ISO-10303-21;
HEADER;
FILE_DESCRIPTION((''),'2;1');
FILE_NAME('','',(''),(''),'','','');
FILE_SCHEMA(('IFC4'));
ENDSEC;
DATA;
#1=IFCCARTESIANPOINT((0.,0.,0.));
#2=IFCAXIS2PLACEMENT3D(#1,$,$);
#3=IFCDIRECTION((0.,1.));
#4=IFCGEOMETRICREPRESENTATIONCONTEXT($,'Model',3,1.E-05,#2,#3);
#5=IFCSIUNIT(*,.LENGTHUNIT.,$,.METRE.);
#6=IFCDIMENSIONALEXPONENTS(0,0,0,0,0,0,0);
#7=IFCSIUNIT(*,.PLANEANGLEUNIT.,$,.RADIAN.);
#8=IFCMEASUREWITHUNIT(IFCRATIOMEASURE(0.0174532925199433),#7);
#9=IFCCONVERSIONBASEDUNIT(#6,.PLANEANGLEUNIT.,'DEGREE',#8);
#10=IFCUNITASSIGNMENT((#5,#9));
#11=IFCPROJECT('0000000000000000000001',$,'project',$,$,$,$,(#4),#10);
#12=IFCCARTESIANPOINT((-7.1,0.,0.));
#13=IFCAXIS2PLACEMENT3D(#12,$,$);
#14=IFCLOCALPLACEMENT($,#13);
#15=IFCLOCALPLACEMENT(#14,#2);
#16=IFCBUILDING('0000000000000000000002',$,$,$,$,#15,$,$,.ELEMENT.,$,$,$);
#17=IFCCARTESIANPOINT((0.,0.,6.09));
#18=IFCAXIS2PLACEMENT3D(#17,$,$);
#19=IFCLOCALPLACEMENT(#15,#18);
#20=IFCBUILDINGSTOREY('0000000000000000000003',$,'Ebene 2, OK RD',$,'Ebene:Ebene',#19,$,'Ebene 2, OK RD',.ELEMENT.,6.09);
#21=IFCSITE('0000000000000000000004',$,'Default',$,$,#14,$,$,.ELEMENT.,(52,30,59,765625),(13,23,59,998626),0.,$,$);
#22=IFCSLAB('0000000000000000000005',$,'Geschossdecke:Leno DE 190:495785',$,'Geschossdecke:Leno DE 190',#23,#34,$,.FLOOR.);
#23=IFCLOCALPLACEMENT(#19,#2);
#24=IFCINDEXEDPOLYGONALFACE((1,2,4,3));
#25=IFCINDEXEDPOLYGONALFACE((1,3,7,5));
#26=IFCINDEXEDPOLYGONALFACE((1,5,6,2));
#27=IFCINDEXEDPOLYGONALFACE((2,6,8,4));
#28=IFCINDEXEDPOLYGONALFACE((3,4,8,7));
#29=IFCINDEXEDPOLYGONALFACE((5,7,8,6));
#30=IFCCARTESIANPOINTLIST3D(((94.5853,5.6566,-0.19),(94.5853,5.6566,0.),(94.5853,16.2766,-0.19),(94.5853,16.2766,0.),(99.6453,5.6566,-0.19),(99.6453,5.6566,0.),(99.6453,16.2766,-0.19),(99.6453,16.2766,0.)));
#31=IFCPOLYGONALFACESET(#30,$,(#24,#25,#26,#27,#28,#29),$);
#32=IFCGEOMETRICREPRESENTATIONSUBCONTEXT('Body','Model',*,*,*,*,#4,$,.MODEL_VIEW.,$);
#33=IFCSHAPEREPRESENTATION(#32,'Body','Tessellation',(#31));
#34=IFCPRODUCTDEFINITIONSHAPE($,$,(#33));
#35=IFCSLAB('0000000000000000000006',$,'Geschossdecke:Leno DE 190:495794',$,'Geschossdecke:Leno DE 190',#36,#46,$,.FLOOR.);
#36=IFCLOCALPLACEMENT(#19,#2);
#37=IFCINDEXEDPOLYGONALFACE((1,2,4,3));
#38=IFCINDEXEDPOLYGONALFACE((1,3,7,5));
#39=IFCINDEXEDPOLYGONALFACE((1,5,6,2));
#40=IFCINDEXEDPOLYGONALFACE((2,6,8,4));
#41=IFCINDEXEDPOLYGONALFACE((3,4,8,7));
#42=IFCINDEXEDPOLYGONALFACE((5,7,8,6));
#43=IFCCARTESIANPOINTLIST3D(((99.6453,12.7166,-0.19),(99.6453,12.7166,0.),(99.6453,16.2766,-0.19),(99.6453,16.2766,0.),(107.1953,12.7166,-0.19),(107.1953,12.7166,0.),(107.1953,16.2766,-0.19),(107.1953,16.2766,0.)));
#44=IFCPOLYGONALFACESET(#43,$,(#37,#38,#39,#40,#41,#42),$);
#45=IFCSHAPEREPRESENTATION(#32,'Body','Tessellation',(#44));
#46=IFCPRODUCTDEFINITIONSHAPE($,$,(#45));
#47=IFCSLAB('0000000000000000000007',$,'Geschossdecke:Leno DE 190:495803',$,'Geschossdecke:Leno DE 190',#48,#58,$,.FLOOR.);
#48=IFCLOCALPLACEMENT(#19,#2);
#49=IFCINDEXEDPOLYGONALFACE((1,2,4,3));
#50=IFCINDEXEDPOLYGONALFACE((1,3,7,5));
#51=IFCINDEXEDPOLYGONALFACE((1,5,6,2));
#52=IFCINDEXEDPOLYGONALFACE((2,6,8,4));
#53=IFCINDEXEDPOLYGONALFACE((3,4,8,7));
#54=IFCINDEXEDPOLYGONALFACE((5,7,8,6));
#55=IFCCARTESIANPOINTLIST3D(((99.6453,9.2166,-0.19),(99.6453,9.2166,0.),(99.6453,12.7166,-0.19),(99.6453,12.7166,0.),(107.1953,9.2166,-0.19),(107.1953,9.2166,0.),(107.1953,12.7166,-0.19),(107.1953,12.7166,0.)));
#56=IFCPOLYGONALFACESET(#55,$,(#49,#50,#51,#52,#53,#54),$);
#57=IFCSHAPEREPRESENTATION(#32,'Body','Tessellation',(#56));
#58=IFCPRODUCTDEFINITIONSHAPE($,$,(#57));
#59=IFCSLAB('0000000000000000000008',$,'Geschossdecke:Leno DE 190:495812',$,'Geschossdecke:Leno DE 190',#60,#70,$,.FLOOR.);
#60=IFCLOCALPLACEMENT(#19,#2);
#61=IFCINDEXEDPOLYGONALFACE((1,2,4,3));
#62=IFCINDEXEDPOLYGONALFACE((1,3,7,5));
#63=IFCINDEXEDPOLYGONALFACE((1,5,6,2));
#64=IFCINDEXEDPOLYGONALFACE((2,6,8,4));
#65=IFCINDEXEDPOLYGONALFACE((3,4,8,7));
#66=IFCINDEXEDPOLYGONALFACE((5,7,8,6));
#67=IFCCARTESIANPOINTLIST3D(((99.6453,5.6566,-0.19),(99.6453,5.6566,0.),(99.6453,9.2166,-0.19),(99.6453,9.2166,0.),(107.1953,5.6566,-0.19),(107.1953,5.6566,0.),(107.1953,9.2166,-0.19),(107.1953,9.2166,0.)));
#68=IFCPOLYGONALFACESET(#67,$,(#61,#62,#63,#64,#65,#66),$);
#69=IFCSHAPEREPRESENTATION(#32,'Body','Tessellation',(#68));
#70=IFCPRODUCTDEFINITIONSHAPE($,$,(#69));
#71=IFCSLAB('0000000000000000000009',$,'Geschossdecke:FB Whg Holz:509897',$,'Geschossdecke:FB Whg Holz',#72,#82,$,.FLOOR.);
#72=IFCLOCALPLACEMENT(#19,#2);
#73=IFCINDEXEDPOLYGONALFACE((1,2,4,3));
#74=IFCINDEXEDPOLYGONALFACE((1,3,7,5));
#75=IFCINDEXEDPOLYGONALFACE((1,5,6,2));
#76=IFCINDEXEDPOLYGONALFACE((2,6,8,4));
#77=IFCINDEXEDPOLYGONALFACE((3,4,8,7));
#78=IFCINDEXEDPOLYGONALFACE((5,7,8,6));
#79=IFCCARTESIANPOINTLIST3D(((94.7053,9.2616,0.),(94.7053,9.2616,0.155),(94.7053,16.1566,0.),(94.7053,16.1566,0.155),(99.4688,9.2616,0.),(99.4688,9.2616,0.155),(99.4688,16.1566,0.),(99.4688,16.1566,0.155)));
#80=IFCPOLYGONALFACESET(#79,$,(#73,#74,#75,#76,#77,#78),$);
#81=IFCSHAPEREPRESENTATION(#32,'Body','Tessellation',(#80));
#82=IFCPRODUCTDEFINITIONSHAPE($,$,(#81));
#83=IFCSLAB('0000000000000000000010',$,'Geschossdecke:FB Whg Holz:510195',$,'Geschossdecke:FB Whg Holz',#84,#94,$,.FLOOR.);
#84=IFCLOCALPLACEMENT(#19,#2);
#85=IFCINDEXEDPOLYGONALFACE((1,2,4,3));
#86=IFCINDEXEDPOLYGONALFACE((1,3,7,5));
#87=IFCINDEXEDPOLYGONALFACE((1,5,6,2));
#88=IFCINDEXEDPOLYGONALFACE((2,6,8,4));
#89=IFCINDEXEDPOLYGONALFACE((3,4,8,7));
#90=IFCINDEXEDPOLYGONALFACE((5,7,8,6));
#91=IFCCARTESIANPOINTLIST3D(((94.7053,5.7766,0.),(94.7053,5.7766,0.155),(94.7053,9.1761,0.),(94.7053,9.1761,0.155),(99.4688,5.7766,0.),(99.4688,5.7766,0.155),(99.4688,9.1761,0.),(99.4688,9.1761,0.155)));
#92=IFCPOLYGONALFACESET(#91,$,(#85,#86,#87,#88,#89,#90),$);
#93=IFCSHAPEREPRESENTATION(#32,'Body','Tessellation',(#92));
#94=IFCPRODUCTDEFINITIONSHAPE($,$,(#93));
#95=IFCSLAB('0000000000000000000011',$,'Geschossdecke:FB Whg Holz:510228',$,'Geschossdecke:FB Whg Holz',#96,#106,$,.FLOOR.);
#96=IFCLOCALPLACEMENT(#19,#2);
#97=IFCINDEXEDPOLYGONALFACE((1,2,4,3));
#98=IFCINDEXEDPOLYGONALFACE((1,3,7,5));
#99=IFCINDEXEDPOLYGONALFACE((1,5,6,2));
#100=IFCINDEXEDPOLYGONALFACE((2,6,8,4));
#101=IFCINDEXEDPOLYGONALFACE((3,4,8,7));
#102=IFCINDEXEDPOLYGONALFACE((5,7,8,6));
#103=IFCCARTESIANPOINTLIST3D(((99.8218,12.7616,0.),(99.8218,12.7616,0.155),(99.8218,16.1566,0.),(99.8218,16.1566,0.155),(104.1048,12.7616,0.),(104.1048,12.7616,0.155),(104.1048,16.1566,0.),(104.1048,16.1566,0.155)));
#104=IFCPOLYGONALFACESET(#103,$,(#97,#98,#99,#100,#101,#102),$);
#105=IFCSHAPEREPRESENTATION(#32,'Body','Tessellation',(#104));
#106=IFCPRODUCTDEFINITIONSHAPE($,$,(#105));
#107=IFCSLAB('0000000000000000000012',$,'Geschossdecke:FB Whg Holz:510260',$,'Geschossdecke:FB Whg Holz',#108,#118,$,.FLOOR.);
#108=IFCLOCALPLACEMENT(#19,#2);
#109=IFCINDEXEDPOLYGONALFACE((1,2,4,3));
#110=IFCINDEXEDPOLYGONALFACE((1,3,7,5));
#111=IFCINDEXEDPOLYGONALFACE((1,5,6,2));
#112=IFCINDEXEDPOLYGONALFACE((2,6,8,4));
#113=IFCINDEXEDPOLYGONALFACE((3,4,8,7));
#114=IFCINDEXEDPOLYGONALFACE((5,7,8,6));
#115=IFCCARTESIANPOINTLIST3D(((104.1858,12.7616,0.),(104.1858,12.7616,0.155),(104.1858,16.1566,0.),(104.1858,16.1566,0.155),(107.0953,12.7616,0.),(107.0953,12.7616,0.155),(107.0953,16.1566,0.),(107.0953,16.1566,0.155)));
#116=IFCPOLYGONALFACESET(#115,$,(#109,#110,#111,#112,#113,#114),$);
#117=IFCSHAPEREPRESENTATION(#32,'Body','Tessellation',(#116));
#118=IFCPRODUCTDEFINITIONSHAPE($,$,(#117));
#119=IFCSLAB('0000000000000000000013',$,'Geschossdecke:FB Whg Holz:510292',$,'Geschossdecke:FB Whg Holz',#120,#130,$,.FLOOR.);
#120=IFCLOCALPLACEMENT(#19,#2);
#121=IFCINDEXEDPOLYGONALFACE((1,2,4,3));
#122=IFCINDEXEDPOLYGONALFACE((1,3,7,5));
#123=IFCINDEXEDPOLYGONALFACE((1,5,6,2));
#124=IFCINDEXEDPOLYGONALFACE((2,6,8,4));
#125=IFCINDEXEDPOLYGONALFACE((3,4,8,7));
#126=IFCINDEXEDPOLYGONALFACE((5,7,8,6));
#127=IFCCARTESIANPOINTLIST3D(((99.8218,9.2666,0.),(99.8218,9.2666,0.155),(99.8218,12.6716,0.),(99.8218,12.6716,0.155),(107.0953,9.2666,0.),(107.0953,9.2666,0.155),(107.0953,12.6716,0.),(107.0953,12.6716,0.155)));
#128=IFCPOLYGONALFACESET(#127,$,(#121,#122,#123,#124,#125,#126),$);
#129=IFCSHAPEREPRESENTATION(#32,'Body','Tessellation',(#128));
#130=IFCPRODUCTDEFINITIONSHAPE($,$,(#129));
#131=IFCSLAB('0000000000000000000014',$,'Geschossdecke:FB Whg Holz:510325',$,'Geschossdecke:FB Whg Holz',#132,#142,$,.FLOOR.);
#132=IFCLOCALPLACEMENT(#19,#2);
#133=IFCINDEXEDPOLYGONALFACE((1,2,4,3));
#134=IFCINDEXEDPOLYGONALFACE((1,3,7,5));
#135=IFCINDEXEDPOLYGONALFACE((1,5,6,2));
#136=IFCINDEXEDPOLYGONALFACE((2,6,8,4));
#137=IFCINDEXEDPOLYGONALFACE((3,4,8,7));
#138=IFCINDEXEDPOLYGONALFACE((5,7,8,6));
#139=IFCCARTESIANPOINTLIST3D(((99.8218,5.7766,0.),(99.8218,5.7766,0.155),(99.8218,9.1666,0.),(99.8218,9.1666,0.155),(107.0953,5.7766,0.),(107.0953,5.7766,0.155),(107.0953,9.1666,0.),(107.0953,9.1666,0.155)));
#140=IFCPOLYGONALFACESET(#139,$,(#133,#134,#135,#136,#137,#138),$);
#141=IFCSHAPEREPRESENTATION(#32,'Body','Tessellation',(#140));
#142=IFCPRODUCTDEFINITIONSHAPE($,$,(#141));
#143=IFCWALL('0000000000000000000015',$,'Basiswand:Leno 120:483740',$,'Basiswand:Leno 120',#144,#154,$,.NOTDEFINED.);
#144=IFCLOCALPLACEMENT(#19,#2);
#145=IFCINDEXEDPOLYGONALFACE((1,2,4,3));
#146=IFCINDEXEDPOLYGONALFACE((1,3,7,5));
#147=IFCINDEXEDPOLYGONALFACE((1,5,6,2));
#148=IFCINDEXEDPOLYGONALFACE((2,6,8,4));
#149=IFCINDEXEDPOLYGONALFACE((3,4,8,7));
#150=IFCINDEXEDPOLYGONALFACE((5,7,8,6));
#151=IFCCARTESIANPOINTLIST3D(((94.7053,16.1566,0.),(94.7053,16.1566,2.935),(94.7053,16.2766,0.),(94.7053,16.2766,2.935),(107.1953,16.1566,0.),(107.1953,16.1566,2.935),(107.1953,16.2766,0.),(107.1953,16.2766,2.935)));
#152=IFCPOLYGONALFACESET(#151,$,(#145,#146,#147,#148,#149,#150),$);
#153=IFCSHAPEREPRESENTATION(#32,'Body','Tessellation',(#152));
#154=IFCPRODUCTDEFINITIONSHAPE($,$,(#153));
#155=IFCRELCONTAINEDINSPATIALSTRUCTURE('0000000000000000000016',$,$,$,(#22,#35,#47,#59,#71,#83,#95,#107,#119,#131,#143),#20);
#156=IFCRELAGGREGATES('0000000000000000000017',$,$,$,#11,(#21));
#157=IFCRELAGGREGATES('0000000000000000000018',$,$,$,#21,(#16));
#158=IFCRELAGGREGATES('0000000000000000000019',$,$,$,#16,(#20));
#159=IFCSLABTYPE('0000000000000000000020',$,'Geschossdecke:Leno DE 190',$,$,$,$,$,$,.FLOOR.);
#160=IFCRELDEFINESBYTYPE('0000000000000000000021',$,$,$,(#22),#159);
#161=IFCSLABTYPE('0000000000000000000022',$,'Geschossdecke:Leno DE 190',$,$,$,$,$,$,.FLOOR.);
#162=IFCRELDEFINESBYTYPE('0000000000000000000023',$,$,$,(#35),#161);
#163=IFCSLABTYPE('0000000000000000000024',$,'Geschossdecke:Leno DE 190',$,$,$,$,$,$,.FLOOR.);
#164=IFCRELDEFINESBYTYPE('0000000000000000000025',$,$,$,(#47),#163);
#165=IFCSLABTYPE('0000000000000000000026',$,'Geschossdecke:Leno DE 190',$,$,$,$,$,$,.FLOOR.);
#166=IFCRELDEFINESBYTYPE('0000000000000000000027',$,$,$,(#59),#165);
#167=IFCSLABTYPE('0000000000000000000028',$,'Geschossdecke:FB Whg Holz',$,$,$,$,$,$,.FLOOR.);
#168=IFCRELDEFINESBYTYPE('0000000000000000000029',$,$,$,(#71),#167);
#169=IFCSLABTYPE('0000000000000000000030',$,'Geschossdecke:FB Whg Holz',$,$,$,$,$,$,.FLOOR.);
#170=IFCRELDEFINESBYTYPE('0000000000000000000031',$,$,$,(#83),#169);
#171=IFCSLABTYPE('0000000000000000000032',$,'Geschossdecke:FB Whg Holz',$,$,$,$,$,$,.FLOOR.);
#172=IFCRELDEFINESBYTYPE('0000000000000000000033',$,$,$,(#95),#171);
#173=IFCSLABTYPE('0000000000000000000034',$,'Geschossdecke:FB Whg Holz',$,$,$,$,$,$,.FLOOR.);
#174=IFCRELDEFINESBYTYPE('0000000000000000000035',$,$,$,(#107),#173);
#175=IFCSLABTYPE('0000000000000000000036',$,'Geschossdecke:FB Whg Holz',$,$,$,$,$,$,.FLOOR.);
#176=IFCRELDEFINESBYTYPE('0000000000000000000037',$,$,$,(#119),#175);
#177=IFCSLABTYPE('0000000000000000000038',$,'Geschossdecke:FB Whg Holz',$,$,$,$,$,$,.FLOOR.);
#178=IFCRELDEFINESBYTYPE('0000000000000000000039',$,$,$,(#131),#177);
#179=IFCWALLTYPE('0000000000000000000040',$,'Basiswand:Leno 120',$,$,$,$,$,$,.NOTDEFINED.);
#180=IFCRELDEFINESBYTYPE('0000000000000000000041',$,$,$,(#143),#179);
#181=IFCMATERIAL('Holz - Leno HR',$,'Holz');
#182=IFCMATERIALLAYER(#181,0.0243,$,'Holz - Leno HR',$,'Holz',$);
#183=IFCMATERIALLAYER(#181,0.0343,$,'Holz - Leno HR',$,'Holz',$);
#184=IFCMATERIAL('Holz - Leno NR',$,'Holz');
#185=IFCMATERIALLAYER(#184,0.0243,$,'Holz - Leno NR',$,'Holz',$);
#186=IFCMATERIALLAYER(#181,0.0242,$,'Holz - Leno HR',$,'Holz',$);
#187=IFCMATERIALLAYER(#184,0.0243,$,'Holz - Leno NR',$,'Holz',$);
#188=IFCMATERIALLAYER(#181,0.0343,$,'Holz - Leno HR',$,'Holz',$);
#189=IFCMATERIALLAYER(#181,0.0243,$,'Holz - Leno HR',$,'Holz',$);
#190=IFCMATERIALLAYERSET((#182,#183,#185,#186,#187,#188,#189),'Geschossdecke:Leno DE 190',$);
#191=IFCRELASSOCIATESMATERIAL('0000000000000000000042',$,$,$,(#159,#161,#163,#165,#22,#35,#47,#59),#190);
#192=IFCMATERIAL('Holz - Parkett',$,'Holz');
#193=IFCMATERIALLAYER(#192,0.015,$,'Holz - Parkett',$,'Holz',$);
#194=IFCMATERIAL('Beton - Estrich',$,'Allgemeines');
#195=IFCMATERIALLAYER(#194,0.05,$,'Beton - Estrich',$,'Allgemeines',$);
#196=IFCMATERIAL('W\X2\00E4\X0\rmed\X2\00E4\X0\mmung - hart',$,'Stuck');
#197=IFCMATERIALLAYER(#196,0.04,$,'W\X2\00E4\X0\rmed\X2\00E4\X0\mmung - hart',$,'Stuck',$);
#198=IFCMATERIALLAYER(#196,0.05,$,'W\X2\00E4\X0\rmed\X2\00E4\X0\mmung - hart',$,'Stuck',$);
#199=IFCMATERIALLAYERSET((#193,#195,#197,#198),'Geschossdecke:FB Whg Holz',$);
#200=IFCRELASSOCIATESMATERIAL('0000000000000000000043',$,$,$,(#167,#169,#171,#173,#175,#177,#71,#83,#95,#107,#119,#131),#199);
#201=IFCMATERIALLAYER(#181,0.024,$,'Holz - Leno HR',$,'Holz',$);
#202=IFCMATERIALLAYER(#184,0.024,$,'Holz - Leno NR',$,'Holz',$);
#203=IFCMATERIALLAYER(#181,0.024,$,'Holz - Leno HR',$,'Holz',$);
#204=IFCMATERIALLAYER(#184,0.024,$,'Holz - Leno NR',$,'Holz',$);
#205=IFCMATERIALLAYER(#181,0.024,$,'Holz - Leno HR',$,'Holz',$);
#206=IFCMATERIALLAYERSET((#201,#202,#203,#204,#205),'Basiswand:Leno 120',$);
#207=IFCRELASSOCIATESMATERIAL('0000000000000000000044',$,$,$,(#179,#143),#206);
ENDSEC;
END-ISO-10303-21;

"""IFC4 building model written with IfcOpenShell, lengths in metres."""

from ifc_helpers import new_model, entity, si_unit, converted_unit, direction, frame, frame_2d, origin, origin_2d_with_axis, place, context, subcontext, project, spatial, rectangle, extrude, material, layer, layer_set, layer_usage, type_object, element, save


model = new_model("IFC4")

# Units and contexts
model_context = context("Model", 3, precision=1e-05, world=origin(), true_north=direction((0.0, 1.0)))
body_context = subcontext(model_context, "Body", "Model", "MODEL_VIEW")
ifc_project = project(units=[si_unit("LENGTHUNIT", "METRE"), converted_unit("PLANEANGLEUNIT", "DEGREE", entity("IfcRatioMeasure", 0.0174532925199433), si_unit("PLANEANGLEUNIT", "RADIAN"), dimensions=[0, 0, 0, 0, 0, 0, 0])], contexts=[model_context])

# Site, building, storey
site_placement = place(None, frame((-7.1, 0.0, 0.0)))
site = spatial("IfcSite", under=ifc_project, at=site_placement, Name="Default", CompositionType="ELEMENT", RefLatitude=(52, 30, 59, 765625), RefLongitude=(13, 23, 59, 998626), RefElevation=0.0)
building_placement = place(site_placement, origin())
building = spatial("IfcBuilding", under=site, at=building_placement, CompositionType="ELEMENT")
storey_placement = place(building_placement, frame((0.0, 0.0, 6.09)))
storey = spatial("IfcBuildingStorey", under=building, at=storey_placement, Name="Ebene 2, OK RD", ObjectType="Ebene:Ebene", LongName="Ebene 2, OK RD", CompositionType="ELEMENT", Elevation=6.09)

# Slabs
ifc_material_1 = material(Name="Holz - Leno HR", Category="Holz")
ifc_layer_1 = layer(ifc_material_1, 0.0243, Name="Holz - Leno HR", Category="Holz")
ifc_layer_2 = layer(ifc_material_1, 0.0343, Name="Holz - Leno HR", Category="Holz")
ifc_material_2 = material(Name="Holz - Leno NR", Category="Holz")
ifc_layer_3 = layer(ifc_material_2, 0.0243, Name="Holz - Leno NR", Category="Holz")
ifc_layer_4 = layer(ifc_material_1, 0.0242, Name="Holz - Leno HR", Category="Holz")
ifc_layer_5 = layer(ifc_material_2, 0.0243, Name="Holz - Leno NR", Category="Holz")
ifc_layer_6 = layer(ifc_material_1, 0.0343, Name="Holz - Leno HR", Category="Holz")
ifc_layer_7 = layer(ifc_material_1, 0.0243, Name="Holz - Leno HR", Category="Holz")
ifc_layer_set_1 = layer_set([ifc_layer_1, ifc_layer_2, ifc_layer_3, ifc_layer_4, ifc_layer_5, ifc_layer_6, ifc_layer_7], Name="Geschossdecke:Leno DE 190")
ifc_layer_usage_1 = layer_usage(ifc_layer_set_1, "AXIS3", "POSITIVE", 0.0)
slab_type_1 = type_object("IfcSlabType", Name="Geschossdecke:Leno DE 190", PredefinedType="FLOOR", material=ifc_layer_set_1)
slab_1_placement = place(storey_placement, origin())
element("IfcSlab", 1, at=slab_1_placement, inside=storey, type_object=slab_type_1, material=ifc_layer_usage_1, Name="Geschossdecke:Leno DE 190:495785", ObjectType="Geschossdecke:Leno DE 190", PredefinedType="FLOOR", context=body_context, shape_type="SweptSolid", body=[
    extrude(rectangle(XDim=10.62, YDim=5.06, at=frame_2d((0.0, 0.0), x_axis=(1.0, 0.0))), frame((97.1153, 10.9666, 0.0), z_axis=(0.0, 0.0, -1.0), x_axis=(0.0, 1.0, 0.0)), (0.0, 0.0, 1.0), 0.19),
])
ifc_layer_usage_2 = layer_usage(ifc_layer_set_1, "AXIS3", "POSITIVE", 0.0)
slab_type_2 = type_object("IfcSlabType", Name="Geschossdecke:Leno DE 190", PredefinedType="FLOOR", material=ifc_layer_set_1)
slab_2_placement = place(storey_placement, origin())
element("IfcSlab", 2, at=slab_2_placement, inside=storey, type_object=slab_type_2, material=ifc_layer_usage_2, Name="Geschossdecke:Leno DE 190:495794", ObjectType="Geschossdecke:Leno DE 190", PredefinedType="FLOOR", context=body_context, shape_type="SweptSolid", body=[
    extrude(rectangle(XDim=3.56, YDim=7.55, at=frame_2d((0.0, 0.0), x_axis=(1.0, 0.0))), frame((103.4203, 14.4966, 0.0), z_axis=(0.0, 0.0, -1.0), x_axis=(0.0, 1.0, 0.0)), (0.0, 0.0, 1.0), 0.19),
])
ifc_layer_usage_3 = layer_usage(ifc_layer_set_1, "AXIS3", "POSITIVE", 0.0)
slab_type_3 = type_object("IfcSlabType", Name="Geschossdecke:Leno DE 190", PredefinedType="FLOOR", material=ifc_layer_set_1)
slab_3_placement = place(storey_placement, origin())
element("IfcSlab", 3, at=slab_3_placement, inside=storey, type_object=slab_type_3, material=ifc_layer_usage_3, Name="Geschossdecke:Leno DE 190:495803", ObjectType="Geschossdecke:Leno DE 190", PredefinedType="FLOOR", context=body_context, shape_type="SweptSolid", body=[
    extrude(rectangle(XDim=3.5, YDim=7.55, at=frame_2d((0.0, 0.0), x_axis=(1.0, 0.0))), frame((103.4203, 10.9666, 0.0), z_axis=(0.0, 0.0, -1.0), x_axis=(0.0, 1.0, 0.0)), (0.0, 0.0, 1.0), 0.19),
])
ifc_layer_usage_4 = layer_usage(ifc_layer_set_1, "AXIS3", "POSITIVE", 0.0)
slab_type_4 = type_object("IfcSlabType", Name="Geschossdecke:Leno DE 190", PredefinedType="FLOOR", material=ifc_layer_set_1)
slab_4_placement = place(storey_placement, origin())
element("IfcSlab", 4, at=slab_4_placement, inside=storey, type_object=slab_type_4, material=ifc_layer_usage_4, Name="Geschossdecke:Leno DE 190:495812", ObjectType="Geschossdecke:Leno DE 190", PredefinedType="FLOOR", context=body_context, shape_type="SweptSolid", body=[
    extrude(rectangle(XDim=3.56, YDim=7.55, at=frame_2d((0.0, 0.0), x_axis=(1.0, 0.0))), frame((103.4203, 7.4366, 0.0), z_axis=(0.0, 0.0, -1.0), x_axis=(0.0, 1.0, 0.0)), (0.0, 0.0, 1.0), 0.19),
])
ifc_material_3 = material(Name="Holz - Parkett", Category="Holz")
ifc_layer_8 = layer(ifc_material_3, 0.015, Name="Holz - Parkett", Category="Holz")
ifc_material_4 = material(Name="Beton - Estrich", Category="Allgemeines")
ifc_layer_9 = layer(ifc_material_4, 0.05, Name="Beton - Estrich", Category="Allgemeines")
ifc_material_5 = material(Name="Wärmedämmung - hart", Category="Stuck")
ifc_layer_10 = layer(ifc_material_5, 0.04, Name="Wärmedämmung - hart", Category="Stuck")
ifc_layer_11 = layer(ifc_material_5, 0.05, Name="Wärmedämmung - hart", Category="Stuck")
ifc_layer_set_2 = layer_set([ifc_layer_8, ifc_layer_9, ifc_layer_10, ifc_layer_11], Name="Geschossdecke:FB Whg Holz")
ifc_layer_usage_5 = layer_usage(ifc_layer_set_2, "AXIS3", "POSITIVE", 0.0)
slab_type_5 = type_object("IfcSlabType", Name="Geschossdecke:FB Whg Holz", PredefinedType="FLOOR", material=ifc_layer_set_2)
slab_5_placement = place(storey_placement, origin())
element("IfcSlab", 5, at=slab_5_placement, inside=storey, type_object=slab_type_5, material=ifc_layer_usage_5, Name="Geschossdecke:FB Whg Holz:509897", ObjectType="Geschossdecke:FB Whg Holz", PredefinedType="FLOOR", context=body_context, shape_type="SweptSolid", body=[
    extrude(rectangle(XDim=6.895, YDim=4.7635, at=frame_2d((0.0, 0.0), x_axis=(1.0, 0.0))), frame((97.0871, 12.7091, 0.155), z_axis=(0.0, 0.0, -1.0), x_axis=(0.0, 1.0, 0.0)), (0.0, 0.0, 1.0), 0.155),
])
ifc_layer_usage_6 = layer_usage(ifc_layer_set_2, "AXIS3", "POSITIVE", 0.0)
slab_type_6 = type_object("IfcSlabType", Name="Geschossdecke:FB Whg Holz", PredefinedType="FLOOR", material=ifc_layer_set_2)
slab_6_placement = place(storey_placement, origin())
element("IfcSlab", 6, at=slab_6_placement, inside=storey, type_object=slab_type_6, material=ifc_layer_usage_6, Name="Geschossdecke:FB Whg Holz:510195", ObjectType="Geschossdecke:FB Whg Holz", PredefinedType="FLOOR", context=body_context, shape_type="SweptSolid", body=[
    extrude(rectangle(XDim=3.3995, YDim=4.7635, at=origin_2d_with_axis()), frame((97.0871, 7.4764, 0.155), z_axis=(0.0, 0.0, -1.0), x_axis=(0.0, 1.0, 0.0)), (0.0, 0.0, 1.0), 0.155),
])
ifc_layer_usage_7 = layer_usage(ifc_layer_set_2, "AXIS3", "POSITIVE", 0.0)
slab_type_7 = type_object("IfcSlabType", Name="Geschossdecke:FB Whg Holz", PredefinedType="FLOOR", material=ifc_layer_set_2)
slab_7_placement = place(storey_placement, origin())
element("IfcSlab", 7, at=slab_7_placement, inside=storey, type_object=slab_type_7, material=ifc_layer_usage_7, Name="Geschossdecke:FB Whg Holz:510228", ObjectType="Geschossdecke:FB Whg Holz", PredefinedType="FLOOR", context=body_context, shape_type="SweptSolid", body=[
    extrude(rectangle(XDim=3.395, YDim=4.283, at=frame_2d((0.0, 0.0), x_axis=(1.0, 0.0))), frame((101.9633, 14.4591, 0.155), z_axis=(0.0, 0.0, -1.0), x_axis=(0.0, 1.0, 0.0)), (0.0, 0.0, 1.0), 0.155),
])
ifc_layer_usage_8 = layer_usage(ifc_layer_set_2, "AXIS3", "POSITIVE", 0.0)
slab_type_8 = type_object("IfcSlabType", Name="Geschossdecke:FB Whg Holz", PredefinedType="FLOOR", material=ifc_layer_set_2)
slab_8_placement = place(storey_placement, origin())
element("IfcSlab", 8, at=slab_8_placement, inside=storey, type_object=slab_type_8, material=ifc_layer_usage_8, Name="Geschossdecke:FB Whg Holz:510260", ObjectType="Geschossdecke:FB Whg Holz", PredefinedType="FLOOR", context=body_context, shape_type="SweptSolid", body=[
    extrude(rectangle(XDim=3.395, YDim=2.9095, at=frame_2d((0.0, 0.0), x_axis=(1.0, 0.0))), frame((105.6406, 14.4591, 0.155), z_axis=(0.0, 0.0, -1.0), x_axis=(0.0, 1.0, 0.0)), (0.0, 0.0, 1.0), 0.155),
])
ifc_layer_usage_9 = layer_usage(ifc_layer_set_2, "AXIS3", "POSITIVE", 0.0)
slab_type_9 = type_object("IfcSlabType", Name="Geschossdecke:FB Whg Holz", PredefinedType="FLOOR", material=ifc_layer_set_2)
slab_9_placement = place(storey_placement, origin())
element("IfcSlab", 9, at=slab_9_placement, inside=storey, type_object=slab_type_9, material=ifc_layer_usage_9, Name="Geschossdecke:FB Whg Holz:510292", ObjectType="Geschossdecke:FB Whg Holz", PredefinedType="FLOOR", context=body_context, shape_type="SweptSolid", body=[
    extrude(rectangle(XDim=3.405, YDim=7.2735, at=frame_2d((0.0, 0.0), x_axis=(1.0, 0.0))), frame((103.4586, 10.9691, 0.155), z_axis=(0.0, 0.0, -1.0), x_axis=(0.0, 1.0, 0.0)), (0.0, 0.0, 1.0), 0.155),
])
ifc_layer_usage_10 = layer_usage(ifc_layer_set_2, "AXIS3", "POSITIVE", 0.0)
slab_type_10 = type_object("IfcSlabType", Name="Geschossdecke:FB Whg Holz", PredefinedType="FLOOR", material=ifc_layer_set_2)
slab_10_placement = place(storey_placement, origin())
element("IfcSlab", 10, at=slab_10_placement, inside=storey, type_object=slab_type_10, material=ifc_layer_usage_10, Name="Geschossdecke:FB Whg Holz:510325", ObjectType="Geschossdecke:FB Whg Holz", PredefinedType="FLOOR", context=body_context, shape_type="SweptSolid", body=[
    extrude(rectangle(XDim=3.39, YDim=7.2735, at=frame_2d((0.0, 0.0), x_axis=(1.0, 0.0))), frame((103.4586, 7.4716, 0.155), z_axis=(0.0, 0.0, -1.0), x_axis=(0.0, 1.0, 0.0)), (0.0, 0.0, 1.0), 0.155),
])

# Wall
ifc_layer_12 = layer(ifc_material_1, 0.024, Name="Holz - Leno HR", Category="Holz")
ifc_layer_13 = layer(ifc_material_2, 0.024, Name="Holz - Leno NR", Category="Holz")
ifc_layer_14 = layer(ifc_material_1, 0.024, Name="Holz - Leno HR", Category="Holz")
ifc_layer_15 = layer(ifc_material_2, 0.024, Name="Holz - Leno NR", Category="Holz")
ifc_layer_16 = layer(ifc_material_1, 0.024, Name="Holz - Leno HR", Category="Holz")
ifc_layer_set_3 = layer_set([ifc_layer_12, ifc_layer_13, ifc_layer_14, ifc_layer_15, ifc_layer_16], Name="Basiswand:Leno 120")
ifc_layer_usage_11 = layer_usage(ifc_layer_set_3, "AXIS2", "NEGATIVE", 0.06)
wall_type_1 = type_object("IfcWallType", Name="Basiswand:Leno 120", PredefinedType="NOTDEFINED", material=ifc_layer_set_3)
wall_1_placement = place(storey_placement, frame((94.7053, 16.2166, 0.0)))
element("IfcWall", 11, at=wall_1_placement, inside=storey, type_object=wall_type_1, material=ifc_layer_usage_11, Name="Basiswand:Leno 120:483740", ObjectType="Basiswand:Leno 120", PredefinedType="NOTDEFINED", context=body_context, shape_type="SweptSolid", body=[
    extrude(rectangle(XDim=12.49, YDim=0.12, at=frame_2d((6.245, 0.0), x_axis=(-1.0, 0.0))), origin(), (0.0, 0.0, 1.0), 2.935),
])

save(model, "model.ifc")
